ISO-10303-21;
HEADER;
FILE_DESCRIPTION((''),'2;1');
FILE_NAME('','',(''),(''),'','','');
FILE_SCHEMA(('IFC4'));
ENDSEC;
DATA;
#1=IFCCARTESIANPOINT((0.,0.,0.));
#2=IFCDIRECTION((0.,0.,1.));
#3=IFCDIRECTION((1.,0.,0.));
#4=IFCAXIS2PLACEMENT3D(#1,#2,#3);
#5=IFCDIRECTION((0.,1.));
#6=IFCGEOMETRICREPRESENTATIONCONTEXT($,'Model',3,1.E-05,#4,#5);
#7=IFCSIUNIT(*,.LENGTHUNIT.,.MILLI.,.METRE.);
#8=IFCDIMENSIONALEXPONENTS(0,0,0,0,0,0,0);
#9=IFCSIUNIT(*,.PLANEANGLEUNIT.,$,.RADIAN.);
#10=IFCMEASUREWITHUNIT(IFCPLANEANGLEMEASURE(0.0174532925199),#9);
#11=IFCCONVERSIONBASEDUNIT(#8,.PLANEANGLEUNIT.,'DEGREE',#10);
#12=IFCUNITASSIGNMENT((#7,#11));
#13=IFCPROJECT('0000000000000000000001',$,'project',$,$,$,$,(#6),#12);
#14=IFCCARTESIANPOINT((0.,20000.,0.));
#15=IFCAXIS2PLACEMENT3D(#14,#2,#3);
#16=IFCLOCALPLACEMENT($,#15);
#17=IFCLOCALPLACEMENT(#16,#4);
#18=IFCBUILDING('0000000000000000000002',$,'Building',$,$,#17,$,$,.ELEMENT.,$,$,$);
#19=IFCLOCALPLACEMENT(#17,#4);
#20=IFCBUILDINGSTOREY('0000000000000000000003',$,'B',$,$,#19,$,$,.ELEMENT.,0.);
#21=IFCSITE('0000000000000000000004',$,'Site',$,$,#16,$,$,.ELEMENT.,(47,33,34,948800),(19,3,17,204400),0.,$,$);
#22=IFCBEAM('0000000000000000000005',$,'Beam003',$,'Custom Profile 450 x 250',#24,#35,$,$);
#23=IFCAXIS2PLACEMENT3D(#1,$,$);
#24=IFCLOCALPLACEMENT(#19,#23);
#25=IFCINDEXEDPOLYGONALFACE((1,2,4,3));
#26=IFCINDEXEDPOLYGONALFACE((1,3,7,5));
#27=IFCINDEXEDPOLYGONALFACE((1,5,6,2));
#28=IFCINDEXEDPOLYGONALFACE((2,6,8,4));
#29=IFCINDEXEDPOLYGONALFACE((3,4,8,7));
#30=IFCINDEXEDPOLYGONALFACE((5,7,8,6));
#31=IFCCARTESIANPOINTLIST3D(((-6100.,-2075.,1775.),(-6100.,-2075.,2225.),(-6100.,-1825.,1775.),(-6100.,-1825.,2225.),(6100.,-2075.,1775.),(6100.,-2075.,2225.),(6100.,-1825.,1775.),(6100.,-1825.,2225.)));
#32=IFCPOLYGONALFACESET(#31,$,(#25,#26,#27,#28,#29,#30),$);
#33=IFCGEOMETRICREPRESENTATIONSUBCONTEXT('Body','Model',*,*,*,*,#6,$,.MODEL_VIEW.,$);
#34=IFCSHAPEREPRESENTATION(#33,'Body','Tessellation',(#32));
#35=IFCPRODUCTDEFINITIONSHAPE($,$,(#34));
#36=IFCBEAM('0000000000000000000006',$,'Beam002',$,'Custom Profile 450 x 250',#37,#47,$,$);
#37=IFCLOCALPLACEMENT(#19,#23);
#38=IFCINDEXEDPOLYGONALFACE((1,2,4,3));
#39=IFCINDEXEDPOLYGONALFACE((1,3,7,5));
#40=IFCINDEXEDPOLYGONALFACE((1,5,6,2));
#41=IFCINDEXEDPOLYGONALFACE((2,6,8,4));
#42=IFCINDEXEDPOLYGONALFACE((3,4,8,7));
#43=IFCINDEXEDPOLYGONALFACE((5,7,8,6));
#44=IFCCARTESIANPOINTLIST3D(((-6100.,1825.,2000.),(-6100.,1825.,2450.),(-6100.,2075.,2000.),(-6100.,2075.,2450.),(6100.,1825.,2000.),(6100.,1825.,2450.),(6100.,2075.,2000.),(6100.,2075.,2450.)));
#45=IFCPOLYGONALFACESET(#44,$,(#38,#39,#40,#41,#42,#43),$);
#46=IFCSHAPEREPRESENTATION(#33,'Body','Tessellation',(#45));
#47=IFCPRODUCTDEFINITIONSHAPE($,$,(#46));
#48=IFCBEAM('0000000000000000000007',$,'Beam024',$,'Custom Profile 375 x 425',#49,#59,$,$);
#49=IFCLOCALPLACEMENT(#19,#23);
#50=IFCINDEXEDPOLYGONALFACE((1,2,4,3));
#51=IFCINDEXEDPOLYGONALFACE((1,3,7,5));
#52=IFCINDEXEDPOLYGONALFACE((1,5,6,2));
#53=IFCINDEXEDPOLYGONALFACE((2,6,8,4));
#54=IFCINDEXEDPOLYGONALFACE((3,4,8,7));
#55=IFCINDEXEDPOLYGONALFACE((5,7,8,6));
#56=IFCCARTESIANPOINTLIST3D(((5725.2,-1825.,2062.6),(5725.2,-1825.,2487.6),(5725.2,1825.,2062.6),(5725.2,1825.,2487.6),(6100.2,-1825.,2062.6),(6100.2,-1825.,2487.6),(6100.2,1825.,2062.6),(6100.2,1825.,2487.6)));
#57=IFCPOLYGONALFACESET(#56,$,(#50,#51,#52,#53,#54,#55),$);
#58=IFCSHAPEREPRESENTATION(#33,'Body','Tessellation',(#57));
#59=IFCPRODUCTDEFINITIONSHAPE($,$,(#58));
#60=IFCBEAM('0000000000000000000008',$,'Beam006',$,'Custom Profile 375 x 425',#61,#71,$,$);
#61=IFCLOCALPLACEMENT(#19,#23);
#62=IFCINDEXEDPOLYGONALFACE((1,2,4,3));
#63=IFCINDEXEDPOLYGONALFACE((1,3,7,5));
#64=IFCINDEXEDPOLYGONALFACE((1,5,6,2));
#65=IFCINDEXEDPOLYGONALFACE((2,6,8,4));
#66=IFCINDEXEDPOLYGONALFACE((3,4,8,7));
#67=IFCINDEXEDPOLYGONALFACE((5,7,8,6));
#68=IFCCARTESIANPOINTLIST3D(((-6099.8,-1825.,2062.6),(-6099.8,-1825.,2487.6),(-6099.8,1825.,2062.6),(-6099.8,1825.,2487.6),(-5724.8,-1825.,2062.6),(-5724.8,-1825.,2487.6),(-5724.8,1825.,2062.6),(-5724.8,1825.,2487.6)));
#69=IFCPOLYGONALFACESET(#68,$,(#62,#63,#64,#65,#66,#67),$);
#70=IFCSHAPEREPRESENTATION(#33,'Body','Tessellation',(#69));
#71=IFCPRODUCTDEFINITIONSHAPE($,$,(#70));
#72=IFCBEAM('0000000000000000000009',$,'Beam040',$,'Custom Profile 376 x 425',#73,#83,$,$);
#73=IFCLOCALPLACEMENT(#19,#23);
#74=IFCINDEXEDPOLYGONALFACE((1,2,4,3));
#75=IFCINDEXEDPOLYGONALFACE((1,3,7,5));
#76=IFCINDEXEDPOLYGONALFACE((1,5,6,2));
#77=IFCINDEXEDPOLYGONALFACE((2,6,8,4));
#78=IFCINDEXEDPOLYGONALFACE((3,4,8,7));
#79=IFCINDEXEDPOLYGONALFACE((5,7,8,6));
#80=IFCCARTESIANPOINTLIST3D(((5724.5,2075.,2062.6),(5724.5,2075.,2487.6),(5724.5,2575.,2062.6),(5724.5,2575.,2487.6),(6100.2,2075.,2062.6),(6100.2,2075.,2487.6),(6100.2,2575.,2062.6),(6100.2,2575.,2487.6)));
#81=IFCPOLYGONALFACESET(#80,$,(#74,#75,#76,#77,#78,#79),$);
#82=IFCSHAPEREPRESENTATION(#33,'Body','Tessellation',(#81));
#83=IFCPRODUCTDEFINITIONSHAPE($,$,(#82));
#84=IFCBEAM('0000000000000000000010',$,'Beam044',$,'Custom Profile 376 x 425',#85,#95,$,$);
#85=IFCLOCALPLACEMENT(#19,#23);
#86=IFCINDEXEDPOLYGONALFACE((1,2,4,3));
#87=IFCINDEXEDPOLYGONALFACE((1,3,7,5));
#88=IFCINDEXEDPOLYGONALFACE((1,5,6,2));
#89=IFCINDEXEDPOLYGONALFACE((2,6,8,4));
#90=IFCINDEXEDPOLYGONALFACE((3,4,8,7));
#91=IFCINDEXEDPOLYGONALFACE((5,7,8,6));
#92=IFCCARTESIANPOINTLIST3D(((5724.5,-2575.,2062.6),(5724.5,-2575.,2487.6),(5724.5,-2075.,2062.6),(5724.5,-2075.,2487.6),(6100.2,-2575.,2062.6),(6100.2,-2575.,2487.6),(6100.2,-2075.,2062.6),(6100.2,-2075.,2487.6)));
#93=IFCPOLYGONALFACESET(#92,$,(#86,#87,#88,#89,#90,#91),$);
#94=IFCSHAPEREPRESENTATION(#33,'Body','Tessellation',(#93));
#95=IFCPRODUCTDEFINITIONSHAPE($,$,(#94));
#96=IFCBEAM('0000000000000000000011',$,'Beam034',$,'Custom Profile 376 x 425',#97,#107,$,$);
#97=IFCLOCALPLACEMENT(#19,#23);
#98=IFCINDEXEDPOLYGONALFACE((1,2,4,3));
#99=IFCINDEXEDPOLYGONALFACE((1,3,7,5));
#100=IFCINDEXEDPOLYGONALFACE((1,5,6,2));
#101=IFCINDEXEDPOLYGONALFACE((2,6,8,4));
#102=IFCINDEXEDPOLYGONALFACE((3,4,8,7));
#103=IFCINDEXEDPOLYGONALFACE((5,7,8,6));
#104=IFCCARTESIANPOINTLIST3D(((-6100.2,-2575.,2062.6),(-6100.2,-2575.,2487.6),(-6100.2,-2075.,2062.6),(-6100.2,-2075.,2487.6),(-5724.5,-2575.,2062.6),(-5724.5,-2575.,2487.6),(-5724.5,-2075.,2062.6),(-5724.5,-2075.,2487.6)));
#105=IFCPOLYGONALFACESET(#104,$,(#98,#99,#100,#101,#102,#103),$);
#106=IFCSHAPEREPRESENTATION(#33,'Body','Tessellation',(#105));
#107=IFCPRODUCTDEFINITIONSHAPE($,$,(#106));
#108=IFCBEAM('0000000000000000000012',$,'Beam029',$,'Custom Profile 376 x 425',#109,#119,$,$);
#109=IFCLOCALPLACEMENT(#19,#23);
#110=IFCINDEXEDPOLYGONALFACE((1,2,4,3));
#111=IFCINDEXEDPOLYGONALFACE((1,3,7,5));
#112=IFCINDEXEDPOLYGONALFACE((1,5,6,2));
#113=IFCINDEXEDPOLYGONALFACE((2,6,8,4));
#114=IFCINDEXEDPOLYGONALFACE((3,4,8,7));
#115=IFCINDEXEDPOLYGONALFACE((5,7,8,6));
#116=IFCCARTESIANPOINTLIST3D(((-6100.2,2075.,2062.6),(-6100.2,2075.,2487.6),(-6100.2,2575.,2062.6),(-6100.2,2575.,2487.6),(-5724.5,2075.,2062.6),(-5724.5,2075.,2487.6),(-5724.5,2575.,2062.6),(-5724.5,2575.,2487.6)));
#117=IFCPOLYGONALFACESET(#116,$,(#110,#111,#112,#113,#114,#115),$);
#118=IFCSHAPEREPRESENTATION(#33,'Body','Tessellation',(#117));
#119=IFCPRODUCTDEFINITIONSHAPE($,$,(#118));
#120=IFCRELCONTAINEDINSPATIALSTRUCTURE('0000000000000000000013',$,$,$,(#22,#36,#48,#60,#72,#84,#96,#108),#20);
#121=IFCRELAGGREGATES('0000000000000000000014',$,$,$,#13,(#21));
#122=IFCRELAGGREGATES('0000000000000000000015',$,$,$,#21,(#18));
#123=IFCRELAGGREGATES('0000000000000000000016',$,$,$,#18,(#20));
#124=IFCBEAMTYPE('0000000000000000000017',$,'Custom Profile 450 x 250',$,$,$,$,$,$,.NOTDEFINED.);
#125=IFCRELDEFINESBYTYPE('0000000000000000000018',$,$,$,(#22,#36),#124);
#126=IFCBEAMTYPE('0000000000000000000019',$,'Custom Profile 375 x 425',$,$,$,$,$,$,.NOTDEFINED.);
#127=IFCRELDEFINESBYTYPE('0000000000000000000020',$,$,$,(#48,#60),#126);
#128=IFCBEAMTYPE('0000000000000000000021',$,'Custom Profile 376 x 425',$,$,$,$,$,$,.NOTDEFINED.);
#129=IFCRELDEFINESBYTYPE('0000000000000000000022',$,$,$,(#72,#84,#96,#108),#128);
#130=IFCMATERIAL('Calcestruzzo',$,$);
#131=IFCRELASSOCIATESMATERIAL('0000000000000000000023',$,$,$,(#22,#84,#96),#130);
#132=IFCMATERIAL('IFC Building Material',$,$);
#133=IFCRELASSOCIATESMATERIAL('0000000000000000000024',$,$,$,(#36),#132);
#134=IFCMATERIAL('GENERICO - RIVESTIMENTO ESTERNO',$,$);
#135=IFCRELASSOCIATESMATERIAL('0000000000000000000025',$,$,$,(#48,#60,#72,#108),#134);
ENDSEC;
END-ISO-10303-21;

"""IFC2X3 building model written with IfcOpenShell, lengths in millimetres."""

from ifc_helpers import new_model, entity, si_unit, converted_unit, direction, frame, frame_2d, origin_with_axes, place, context, subcontext, project, spatial, polyline, rectangle, outline, extrude, material, type_object, element, save


model = new_model("IFC2X3")

# Units and contexts
model_context = context("Model", 3, precision=1e-05, world=origin_with_axes(), true_north=direction((0.0, 1.0)))
body_context = subcontext(model_context, "Body", "Model", "MODEL_VIEW")
ifc_project = project(units=[si_unit("LENGTHUNIT", "METRE", prefix="MILLI"), converted_unit("PLANEANGLEUNIT", "DEGREE", entity("IfcPlaneAngleMeasure", 0.0174532925199), si_unit("PLANEANGLEUNIT", "RADIAN"), dimensions=[0, 0, 0, 0, 0, 0, 0])], contexts=[model_context])

# Site, building, storey
site_placement = place(None, frame((0.0, 20000.0, 0.0), z_axis=(0.0, 0.0, 1.0), x_axis=(1.0, 0.0, 0.0)))
site = spatial("IfcSite", under=ifc_project, at=site_placement, Name="Site", CompositionType="ELEMENT", RefLatitude=(47, 33, 34, 948800), RefLongitude=(19, 3, 17, 204400), RefElevation=0.0)
building_placement = place(site_placement, origin_with_axes())
building = spatial("IfcBuilding", under=site, at=building_placement, Name="Building", CompositionType="ELEMENT")
storey_placement = place(building_placement, origin_with_axes())
storey = spatial("IfcBuildingStorey", under=building, at=storey_placement, Name="B", CompositionType="ELEMENT", Elevation=0.0)

# Beams
ifc_material_1 = material(Name="Calcestruzzo")
beam_type_1 = type_object("IfcBeamType", Name="Custom Profile 450 x 250", PredefinedType="NOTDEFINED")
beam_1_placement = place(storey_placement, frame((-6100.0, -1950.0, 2225.0), z_axis=(0.0, 0.0, 1.0), x_axis=(0.0, -1.0, 0.0)))
element("IfcBeam", 1, at=beam_1_placement, inside=storey, type_object=beam_type_1, material=ifc_material_1, Name="Beam003", ObjectType="Custom Profile 450 x 250", context=body_context, shape_type="SweptSolid", body=[
    extrude(rectangle(XDim=450.0, YDim=250.0, at=frame_2d((-225.0, 0.0), x_axis=(1.0, 0.0))), frame((0.0, 0.0, 0.0), z_axis=(0.0, 1.0, 0.0), x_axis=(0.0, 0.0, 1.0)), (0.0, 0.0, 1.0), 12200.0),
])
ifc_material_2 = material(Name="IFC Building Material")
beam_2_placement = place(storey_placement, frame((-6100.0, 1950.0, 2225.0), z_axis=(0.0, 0.0, 1.0), x_axis=(0.0, -1.0, 0.0)))
element("IfcBeam", 2, at=beam_2_placement, inside=storey, type_object=beam_type_1, material=ifc_material_2, Name="Beam002", ObjectType="Custom Profile 450 x 250", context=body_context, shape_type="SweptSolid", body=[
    extrude(outline(polyline([(-125.0, -225.0), (125.0, -225.0), (125.0, 225.0), (-125.0, 225.0), (-125.0, -225.0)])), frame((0.0, 12200.0, 0.0), z_axis=(0.0, -1.0, 0.0), x_axis=(1.0, 0.0, 0.0)), (0.0, 0.0, 1.0), 12200.0),
])
ifc_material_3 = material(Name="GENERICO - RIVESTIMENTO ESTERNO")
beam_type_2 = type_object("IfcBeamType", Name="Custom Profile 375 x 425", PredefinedType="NOTDEFINED")
for number, where, z_axis, x_axis, name in (
    (3, (5912.7, -1825.0, 2487.6), (0.0, 0.0, 1.0), (1.0, 0.0, 0.0), "Beam024"),
    (4, (-5912.3, -1825.0, 2487.6), (0.0, 0.0, 1.0), (1.0, 0.0, 0.0), "Beam006"),
):
    element("IfcBeam", number, at=place(storey_placement, frame(where, z_axis=z_axis, x_axis=x_axis)), inside=storey, type_object=beam_type_2, material=ifc_material_3, Name=name, ObjectType="Custom Profile 375 x 425", context=body_context, shape_type="SweptSolid", body=[
        extrude(rectangle(XDim=425.0, YDim=375.0, at=frame_2d((-212.5, 0.0), x_axis=(1.0, 0.0))), frame((0.0, 0.0, 0.0), z_axis=(0.0, 1.0, 0.0), x_axis=(0.0, 0.0, 1.0)), (0.0, 0.0, 1.0), 3650.0),
    ])
beam_type_3 = type_object("IfcBeamType", Name="Custom Profile 376 x 425", PredefinedType="NOTDEFINED")
beam_3_placement = place(storey_placement, frame((5912.3, 2575.0, 2487.6), z_axis=(0.0, 0.0, 1.0), x_axis=(-1.0, 0.0, 0.0)))
element("IfcBeam", 5, at=beam_3_placement, inside=storey, type_object=beam_type_3, material=ifc_material_3, Name="Beam040", ObjectType="Custom Profile 376 x 425", context=body_context, shape_type="SweptSolid", body=[
    extrude(rectangle(XDim=425.0, YDim=375.7, at=frame_2d((-212.5, 0.0), x_axis=(1.0, 0.0))), frame((0.0, 0.0, 0.0), z_axis=(0.0, 1.0, 0.0), x_axis=(0.0, 0.0, 1.0)), (0.0, 0.0, 1.0), 500.0),
])
beam_4_placement = place(storey_placement, frame((5912.3, -2075.0, 2487.6), z_axis=(0.0, 0.0, 1.0), x_axis=(-1.0, 0.0, 0.0)))
element("IfcBeam", 6, at=beam_4_placement, inside=storey, type_object=beam_type_3, material=ifc_material_1, Name="Beam044", ObjectType="Custom Profile 376 x 425", context=body_context, shape_type="SweptSolid", body=[
    extrude(rectangle(XDim=425.0, YDim=375.7, at=frame_2d((-212.5, 0.0), x_axis=(1.0, 0.0))), frame((0.0, 0.0, 0.0), z_axis=(0.0, 1.0, 0.0), x_axis=(0.0, 0.0, 1.0)), (0.0, 0.0, 1.0), 500.0),
])
beam_5_placement = place(storey_placement, frame((-5912.3, -2575.0, 2487.6), z_axis=(0.0, 0.0, 1.0), x_axis=(1.0, 0.0, 0.0)))
element("IfcBeam", 7, at=beam_5_placement, inside=storey, type_object=beam_type_3, material=ifc_material_1, Name="Beam034", ObjectType="Custom Profile 376 x 425", context=body_context, shape_type="SweptSolid", body=[
    extrude(rectangle(XDim=425.0, YDim=375.7, at=frame_2d((-212.5, 0.0), x_axis=(1.0, 0.0))), frame((0.0, 0.0, 0.0), z_axis=(0.0, 1.0, 0.0), x_axis=(0.0, 0.0, 1.0)), (0.0, 0.0, 1.0), 500.0),
])
beam_6_placement = place(storey_placement, frame((-5912.3, 2075.0, 2487.6), z_axis=(0.0, 0.0, 1.0), x_axis=(1.0, 0.0, 0.0)))
element("IfcBeam", 8, at=beam_6_placement, inside=storey, type_object=beam_type_3, material=ifc_material_3, Name="Beam029", ObjectType="Custom Profile 376 x 425", context=body_context, shape_type="SweptSolid", body=[
    extrude(rectangle(XDim=425.0, YDim=375.7, at=frame_2d((-212.5, 0.0), x_axis=(1.0, 0.0))), frame((0.0, 0.0, 0.0), z_axis=(0.0, 1.0, 0.0), x_axis=(0.0, 0.0, 1.0)), (0.0, 0.0, 1.0), 500.0),
])

save(model, "model.ifc")
